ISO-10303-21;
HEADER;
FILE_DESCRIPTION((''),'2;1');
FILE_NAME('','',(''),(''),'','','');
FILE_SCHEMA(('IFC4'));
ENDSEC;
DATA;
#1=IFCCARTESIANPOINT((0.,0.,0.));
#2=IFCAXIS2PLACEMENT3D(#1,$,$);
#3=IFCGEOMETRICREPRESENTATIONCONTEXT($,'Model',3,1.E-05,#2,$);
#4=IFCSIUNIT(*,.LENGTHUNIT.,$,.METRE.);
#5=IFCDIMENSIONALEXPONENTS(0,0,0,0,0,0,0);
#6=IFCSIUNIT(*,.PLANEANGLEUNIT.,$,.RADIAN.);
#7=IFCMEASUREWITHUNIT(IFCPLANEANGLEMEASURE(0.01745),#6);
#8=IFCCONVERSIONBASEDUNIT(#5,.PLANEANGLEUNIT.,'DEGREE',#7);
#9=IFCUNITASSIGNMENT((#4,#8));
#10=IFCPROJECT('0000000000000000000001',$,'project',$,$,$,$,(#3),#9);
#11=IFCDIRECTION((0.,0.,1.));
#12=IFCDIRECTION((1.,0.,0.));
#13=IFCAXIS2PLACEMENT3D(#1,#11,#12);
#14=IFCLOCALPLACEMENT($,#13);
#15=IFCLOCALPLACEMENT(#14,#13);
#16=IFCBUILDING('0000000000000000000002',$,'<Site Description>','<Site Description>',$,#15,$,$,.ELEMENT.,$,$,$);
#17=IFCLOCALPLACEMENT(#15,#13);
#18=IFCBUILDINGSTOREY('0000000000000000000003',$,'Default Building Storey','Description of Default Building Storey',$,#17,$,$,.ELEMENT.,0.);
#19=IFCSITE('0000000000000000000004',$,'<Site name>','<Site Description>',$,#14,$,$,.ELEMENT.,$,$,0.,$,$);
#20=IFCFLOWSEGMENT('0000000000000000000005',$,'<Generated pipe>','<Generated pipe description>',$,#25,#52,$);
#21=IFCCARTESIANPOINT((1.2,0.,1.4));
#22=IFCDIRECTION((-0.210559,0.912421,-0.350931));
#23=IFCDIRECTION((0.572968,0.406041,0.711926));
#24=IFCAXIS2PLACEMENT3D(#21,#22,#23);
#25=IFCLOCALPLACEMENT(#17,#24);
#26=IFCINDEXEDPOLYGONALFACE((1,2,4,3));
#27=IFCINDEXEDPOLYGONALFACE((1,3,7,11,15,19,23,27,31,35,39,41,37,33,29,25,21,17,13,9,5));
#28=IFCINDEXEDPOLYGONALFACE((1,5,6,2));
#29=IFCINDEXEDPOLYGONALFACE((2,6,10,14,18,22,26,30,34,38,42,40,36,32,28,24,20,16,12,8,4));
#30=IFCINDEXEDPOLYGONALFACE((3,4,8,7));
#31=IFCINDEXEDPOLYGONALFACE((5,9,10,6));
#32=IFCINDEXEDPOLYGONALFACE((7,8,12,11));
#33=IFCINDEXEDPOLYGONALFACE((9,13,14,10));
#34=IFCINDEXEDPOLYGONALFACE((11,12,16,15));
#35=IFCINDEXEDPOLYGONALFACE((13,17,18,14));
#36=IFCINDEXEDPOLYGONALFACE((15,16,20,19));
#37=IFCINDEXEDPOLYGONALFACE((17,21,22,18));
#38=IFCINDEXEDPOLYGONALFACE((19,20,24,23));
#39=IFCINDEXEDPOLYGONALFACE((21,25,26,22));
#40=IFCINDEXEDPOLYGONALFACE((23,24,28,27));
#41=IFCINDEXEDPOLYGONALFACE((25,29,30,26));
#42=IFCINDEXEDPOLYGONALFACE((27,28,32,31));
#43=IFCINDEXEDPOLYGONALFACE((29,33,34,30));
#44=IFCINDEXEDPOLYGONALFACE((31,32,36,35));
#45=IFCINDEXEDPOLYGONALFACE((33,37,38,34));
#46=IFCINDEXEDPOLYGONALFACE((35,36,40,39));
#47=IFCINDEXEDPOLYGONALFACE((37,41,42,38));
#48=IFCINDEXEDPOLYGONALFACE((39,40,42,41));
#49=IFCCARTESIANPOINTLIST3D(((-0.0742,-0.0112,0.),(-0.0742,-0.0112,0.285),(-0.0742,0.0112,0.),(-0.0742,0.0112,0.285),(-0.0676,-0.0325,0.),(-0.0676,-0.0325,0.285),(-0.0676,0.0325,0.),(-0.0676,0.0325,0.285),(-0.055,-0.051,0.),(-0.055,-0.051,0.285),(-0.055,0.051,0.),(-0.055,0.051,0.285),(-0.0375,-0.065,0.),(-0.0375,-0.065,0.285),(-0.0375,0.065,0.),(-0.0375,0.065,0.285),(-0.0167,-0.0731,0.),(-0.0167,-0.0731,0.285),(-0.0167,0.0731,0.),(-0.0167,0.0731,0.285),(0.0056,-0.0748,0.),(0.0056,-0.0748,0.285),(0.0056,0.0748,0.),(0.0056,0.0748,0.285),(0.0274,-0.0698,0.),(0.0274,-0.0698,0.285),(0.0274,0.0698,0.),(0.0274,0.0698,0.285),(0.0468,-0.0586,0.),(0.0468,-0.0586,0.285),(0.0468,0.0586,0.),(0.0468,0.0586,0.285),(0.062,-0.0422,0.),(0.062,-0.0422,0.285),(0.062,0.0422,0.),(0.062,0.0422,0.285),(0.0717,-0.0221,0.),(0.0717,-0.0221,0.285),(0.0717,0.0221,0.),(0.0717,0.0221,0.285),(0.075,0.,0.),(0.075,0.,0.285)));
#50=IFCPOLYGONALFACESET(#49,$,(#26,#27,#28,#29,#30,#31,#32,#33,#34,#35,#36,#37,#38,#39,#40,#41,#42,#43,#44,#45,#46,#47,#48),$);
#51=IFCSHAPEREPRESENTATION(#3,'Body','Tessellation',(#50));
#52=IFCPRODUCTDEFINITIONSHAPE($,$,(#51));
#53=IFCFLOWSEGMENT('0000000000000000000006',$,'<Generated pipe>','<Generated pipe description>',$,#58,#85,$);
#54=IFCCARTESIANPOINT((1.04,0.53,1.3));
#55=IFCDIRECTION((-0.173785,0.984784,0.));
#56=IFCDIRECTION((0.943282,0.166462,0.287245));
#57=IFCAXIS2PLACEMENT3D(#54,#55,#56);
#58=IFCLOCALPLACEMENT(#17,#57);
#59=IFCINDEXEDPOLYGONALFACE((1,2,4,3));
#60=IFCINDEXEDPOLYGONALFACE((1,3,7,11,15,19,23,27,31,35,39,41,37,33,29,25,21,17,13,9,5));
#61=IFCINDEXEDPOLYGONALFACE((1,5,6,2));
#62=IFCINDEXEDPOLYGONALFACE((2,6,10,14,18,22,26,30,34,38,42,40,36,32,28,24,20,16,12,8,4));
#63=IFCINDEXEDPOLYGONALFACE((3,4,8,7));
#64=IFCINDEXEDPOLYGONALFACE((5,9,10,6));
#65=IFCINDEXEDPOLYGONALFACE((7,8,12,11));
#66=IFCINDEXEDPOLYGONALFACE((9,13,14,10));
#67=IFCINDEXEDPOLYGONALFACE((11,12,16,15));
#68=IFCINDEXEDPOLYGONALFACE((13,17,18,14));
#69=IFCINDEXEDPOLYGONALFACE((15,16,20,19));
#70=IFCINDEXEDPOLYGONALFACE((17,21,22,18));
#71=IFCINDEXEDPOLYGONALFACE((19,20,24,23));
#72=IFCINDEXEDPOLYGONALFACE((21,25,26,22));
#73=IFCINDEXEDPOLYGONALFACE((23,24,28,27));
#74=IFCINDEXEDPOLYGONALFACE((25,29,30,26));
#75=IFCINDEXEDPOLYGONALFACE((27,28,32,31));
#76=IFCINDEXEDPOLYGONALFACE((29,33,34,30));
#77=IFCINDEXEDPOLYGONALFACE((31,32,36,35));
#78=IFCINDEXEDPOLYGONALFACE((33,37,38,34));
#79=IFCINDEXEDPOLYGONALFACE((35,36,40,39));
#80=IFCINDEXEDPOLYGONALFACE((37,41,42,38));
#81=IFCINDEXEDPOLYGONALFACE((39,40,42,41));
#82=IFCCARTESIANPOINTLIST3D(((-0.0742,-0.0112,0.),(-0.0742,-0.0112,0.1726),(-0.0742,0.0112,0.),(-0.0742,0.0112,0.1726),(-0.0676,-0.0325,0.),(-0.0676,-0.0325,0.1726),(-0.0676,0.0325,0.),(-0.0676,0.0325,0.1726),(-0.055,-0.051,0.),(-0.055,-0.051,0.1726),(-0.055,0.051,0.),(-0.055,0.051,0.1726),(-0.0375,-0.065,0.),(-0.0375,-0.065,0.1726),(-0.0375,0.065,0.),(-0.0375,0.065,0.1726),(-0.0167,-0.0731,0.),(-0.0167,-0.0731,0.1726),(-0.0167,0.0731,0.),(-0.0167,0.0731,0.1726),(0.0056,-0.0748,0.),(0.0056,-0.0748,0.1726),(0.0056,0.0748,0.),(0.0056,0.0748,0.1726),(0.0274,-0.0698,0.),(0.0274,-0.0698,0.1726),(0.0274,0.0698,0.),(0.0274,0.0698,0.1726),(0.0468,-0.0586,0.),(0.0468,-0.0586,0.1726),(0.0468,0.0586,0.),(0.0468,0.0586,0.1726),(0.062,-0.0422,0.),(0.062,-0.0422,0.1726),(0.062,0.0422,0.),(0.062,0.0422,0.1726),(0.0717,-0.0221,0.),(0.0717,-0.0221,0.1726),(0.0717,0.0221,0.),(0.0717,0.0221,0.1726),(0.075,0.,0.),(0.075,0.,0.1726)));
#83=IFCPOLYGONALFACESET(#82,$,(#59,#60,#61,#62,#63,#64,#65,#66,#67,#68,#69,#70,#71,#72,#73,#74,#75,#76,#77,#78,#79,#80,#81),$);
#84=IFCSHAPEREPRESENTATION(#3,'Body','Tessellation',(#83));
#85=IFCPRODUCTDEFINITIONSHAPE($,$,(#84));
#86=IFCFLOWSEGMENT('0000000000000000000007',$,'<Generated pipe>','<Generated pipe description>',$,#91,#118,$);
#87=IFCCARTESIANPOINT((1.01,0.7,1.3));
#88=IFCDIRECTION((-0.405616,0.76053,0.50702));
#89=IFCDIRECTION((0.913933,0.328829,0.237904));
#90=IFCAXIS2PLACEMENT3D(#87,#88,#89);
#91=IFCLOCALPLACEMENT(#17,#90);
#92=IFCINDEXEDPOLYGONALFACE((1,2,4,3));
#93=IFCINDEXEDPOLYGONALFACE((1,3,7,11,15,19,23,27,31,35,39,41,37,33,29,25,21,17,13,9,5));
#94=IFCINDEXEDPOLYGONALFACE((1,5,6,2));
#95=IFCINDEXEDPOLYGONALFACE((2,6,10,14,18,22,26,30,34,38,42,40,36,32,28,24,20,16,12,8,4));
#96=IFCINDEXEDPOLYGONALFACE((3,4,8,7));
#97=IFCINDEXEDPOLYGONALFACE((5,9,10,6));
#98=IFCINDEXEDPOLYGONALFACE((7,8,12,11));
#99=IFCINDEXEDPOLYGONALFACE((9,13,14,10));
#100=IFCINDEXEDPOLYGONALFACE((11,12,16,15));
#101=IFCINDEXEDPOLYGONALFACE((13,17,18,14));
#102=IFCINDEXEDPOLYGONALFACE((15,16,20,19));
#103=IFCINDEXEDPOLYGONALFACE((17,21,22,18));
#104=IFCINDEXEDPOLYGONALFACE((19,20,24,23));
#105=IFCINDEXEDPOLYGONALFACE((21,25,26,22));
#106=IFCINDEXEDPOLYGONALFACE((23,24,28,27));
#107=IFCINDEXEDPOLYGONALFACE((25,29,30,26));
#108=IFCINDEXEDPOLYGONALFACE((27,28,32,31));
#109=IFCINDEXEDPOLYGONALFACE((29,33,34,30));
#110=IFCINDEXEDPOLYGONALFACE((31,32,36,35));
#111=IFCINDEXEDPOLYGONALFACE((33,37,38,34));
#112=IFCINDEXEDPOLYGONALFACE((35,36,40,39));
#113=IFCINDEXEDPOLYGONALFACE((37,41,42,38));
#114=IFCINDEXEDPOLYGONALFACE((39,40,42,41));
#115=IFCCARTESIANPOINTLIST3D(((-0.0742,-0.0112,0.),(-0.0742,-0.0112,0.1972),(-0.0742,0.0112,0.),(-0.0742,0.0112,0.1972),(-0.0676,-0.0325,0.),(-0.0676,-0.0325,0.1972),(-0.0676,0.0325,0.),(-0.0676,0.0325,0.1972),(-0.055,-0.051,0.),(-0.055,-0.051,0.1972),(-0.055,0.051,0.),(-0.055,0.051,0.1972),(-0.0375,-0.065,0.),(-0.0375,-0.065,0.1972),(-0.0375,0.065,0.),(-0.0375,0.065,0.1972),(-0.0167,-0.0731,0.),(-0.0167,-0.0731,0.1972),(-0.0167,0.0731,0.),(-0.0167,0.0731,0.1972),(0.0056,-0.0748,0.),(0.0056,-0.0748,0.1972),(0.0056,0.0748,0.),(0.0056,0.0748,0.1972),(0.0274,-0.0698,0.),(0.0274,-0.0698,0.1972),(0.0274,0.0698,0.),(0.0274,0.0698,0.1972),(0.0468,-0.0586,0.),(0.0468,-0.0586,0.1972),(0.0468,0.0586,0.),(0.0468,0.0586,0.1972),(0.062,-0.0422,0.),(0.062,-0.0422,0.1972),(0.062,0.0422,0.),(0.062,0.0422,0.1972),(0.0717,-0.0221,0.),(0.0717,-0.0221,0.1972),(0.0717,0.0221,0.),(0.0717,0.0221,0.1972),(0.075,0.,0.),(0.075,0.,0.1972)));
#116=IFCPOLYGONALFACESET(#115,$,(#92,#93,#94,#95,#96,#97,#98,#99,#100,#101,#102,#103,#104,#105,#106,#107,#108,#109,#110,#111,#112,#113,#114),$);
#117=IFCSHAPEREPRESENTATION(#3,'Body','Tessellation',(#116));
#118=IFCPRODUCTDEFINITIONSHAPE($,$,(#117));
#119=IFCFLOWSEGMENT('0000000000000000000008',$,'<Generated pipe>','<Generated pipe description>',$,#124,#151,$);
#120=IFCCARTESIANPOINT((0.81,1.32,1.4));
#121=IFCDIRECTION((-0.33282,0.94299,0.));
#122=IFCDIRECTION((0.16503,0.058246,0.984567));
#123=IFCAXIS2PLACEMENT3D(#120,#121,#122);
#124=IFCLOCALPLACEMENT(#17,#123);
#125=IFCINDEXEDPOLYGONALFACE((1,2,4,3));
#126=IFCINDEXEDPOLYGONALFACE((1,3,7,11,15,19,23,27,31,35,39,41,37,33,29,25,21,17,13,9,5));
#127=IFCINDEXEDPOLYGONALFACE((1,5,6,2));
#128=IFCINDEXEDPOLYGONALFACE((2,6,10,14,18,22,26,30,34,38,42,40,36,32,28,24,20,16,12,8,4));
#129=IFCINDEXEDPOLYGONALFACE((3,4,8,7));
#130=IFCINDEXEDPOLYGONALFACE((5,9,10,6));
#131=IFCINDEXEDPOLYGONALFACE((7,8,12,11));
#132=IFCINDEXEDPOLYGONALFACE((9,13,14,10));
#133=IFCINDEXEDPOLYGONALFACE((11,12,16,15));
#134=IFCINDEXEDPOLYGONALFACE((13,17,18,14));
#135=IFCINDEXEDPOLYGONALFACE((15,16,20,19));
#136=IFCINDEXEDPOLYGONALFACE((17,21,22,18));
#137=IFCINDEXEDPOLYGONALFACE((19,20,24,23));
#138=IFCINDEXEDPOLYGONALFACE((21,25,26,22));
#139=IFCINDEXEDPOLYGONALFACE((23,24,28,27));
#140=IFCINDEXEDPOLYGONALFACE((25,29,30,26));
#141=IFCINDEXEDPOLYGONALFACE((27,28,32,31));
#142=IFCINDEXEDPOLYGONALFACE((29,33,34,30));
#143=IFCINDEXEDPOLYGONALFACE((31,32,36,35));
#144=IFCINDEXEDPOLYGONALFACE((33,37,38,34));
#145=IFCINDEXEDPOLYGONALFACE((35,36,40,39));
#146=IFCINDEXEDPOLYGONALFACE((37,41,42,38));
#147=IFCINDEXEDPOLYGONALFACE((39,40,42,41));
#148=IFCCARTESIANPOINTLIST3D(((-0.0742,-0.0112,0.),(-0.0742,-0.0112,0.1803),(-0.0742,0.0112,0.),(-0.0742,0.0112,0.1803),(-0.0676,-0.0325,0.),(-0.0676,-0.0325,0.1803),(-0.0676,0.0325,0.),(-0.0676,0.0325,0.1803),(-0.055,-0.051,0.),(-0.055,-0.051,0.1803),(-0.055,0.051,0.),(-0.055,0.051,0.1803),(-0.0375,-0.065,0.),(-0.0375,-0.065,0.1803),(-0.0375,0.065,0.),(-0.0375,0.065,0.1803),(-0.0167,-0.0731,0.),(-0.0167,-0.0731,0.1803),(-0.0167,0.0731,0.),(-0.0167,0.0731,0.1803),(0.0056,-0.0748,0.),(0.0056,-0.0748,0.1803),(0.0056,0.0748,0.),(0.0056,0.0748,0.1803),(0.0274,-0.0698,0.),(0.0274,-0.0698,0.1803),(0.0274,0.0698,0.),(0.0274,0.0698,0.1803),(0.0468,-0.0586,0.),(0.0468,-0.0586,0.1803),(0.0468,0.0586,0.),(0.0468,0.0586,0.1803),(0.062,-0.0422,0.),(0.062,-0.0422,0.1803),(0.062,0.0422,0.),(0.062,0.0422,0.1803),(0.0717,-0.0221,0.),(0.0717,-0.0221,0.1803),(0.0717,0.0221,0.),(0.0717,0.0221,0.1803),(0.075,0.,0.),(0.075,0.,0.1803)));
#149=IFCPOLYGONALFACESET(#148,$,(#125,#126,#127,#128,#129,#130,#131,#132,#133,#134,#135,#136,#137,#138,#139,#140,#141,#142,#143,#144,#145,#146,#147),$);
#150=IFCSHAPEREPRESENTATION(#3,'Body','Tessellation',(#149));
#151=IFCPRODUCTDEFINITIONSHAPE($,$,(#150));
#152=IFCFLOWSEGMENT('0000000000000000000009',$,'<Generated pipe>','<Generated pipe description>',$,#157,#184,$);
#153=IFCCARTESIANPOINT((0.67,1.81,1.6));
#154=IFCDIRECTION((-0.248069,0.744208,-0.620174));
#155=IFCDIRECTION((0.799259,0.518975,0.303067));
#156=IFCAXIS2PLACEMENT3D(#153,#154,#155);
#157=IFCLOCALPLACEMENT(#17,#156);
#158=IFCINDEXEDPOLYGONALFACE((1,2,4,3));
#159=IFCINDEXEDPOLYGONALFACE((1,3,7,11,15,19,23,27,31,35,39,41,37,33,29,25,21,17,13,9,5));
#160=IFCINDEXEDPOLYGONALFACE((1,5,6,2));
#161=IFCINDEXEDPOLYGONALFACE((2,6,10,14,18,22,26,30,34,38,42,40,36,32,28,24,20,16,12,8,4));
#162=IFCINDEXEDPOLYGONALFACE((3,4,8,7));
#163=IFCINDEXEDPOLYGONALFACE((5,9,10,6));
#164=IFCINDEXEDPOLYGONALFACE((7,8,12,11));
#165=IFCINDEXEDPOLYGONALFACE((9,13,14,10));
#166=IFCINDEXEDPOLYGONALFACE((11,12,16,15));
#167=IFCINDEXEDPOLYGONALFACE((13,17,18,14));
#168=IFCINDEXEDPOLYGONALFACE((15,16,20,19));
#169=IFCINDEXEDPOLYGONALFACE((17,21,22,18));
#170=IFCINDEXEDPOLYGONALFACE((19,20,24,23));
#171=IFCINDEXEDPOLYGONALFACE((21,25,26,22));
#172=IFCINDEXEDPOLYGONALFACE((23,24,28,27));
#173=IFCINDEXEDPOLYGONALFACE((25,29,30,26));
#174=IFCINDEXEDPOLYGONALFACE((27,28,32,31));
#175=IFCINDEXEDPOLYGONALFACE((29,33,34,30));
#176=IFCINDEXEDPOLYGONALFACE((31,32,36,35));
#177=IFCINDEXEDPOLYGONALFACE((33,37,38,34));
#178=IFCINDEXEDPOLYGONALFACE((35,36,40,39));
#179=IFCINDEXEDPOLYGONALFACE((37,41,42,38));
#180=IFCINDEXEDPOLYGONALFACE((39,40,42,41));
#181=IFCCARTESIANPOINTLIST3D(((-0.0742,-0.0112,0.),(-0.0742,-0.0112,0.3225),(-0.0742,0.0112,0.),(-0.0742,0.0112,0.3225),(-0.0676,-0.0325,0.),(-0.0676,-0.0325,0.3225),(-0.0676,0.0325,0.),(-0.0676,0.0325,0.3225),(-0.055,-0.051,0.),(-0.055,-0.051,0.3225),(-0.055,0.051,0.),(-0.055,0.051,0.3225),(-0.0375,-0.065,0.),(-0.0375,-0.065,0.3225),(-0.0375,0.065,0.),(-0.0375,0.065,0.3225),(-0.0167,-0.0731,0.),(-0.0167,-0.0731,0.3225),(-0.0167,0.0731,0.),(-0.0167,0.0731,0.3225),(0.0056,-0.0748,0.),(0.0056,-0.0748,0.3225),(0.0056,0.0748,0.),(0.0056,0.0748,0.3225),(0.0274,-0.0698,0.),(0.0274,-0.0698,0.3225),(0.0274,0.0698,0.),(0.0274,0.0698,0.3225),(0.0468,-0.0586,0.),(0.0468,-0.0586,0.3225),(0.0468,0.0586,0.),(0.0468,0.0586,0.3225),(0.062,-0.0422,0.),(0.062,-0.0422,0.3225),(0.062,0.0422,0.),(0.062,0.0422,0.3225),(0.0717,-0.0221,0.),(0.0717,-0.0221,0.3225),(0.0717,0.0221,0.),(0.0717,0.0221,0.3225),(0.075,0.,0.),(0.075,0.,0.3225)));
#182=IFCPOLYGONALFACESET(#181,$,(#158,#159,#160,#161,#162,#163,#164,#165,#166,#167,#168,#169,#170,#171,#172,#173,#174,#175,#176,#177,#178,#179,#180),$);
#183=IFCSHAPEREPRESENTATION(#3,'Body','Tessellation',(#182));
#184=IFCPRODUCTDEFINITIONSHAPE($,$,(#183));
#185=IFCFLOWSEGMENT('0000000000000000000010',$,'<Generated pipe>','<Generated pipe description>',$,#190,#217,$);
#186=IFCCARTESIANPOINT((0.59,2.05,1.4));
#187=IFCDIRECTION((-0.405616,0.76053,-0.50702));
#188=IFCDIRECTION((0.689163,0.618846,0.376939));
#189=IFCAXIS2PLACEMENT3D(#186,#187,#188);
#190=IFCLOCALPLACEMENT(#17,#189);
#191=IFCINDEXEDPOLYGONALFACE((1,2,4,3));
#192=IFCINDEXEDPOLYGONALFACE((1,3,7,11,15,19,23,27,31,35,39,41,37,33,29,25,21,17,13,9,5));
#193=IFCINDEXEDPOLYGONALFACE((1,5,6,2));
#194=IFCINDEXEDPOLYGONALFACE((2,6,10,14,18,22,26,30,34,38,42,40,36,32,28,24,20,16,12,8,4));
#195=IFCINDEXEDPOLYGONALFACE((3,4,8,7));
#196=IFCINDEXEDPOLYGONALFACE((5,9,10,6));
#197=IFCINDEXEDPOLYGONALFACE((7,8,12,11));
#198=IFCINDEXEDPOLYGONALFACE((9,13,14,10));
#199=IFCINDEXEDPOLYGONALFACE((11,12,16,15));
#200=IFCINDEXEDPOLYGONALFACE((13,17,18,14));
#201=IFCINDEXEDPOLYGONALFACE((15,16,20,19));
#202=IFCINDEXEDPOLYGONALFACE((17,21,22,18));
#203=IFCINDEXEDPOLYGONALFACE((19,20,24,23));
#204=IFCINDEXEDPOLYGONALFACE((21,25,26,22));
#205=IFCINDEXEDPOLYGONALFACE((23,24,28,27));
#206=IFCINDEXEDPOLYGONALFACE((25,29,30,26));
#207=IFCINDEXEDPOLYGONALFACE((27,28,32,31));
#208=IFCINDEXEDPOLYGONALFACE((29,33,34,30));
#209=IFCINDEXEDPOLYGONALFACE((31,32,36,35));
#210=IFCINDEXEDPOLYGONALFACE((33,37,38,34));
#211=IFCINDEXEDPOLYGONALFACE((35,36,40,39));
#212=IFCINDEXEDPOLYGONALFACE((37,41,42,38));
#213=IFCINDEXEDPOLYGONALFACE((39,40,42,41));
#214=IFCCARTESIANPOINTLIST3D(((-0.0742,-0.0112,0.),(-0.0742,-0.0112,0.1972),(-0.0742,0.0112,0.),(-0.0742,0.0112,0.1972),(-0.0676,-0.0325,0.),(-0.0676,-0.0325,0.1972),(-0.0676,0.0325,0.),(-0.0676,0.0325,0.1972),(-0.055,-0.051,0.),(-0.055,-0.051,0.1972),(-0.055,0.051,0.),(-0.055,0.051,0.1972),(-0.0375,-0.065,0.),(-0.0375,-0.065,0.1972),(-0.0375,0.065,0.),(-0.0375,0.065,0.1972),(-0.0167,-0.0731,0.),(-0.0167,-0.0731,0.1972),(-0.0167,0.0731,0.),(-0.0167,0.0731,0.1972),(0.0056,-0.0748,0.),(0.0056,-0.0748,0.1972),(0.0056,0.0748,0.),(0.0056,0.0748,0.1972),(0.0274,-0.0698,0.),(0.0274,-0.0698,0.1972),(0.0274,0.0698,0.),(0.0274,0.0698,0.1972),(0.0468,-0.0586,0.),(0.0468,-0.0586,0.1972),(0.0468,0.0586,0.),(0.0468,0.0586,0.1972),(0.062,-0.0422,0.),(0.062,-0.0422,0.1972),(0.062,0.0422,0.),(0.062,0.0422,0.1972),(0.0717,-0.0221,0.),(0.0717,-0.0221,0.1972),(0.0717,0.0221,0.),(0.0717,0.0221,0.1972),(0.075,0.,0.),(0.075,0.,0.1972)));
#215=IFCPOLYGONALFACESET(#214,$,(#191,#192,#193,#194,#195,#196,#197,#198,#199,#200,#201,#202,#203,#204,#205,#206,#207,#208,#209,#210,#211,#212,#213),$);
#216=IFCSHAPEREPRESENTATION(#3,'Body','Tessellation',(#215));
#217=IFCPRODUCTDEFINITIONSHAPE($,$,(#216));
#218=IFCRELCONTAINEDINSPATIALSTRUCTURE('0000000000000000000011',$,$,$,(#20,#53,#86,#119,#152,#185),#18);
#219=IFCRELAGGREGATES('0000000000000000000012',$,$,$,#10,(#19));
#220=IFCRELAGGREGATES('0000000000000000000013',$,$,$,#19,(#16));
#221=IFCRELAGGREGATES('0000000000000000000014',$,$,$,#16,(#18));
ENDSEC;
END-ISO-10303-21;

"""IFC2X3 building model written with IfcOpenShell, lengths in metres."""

from ifc_helpers import new_model, entity, si_unit, converted_unit, frame, origin, origin_with_axes, origin_2d_with_axis, place, context, project, spatial, circle, extrude, element, save


model = new_model("IFC2X3")

# Units and contexts
model_context = context("Model", 3, precision=1e-05, world=origin())
ifc_project = project(units=[si_unit("LENGTHUNIT", "METRE"), converted_unit("PLANEANGLEUNIT", "DEGREE", entity("IfcPlaneAngleMeasure", 0.01745), si_unit("PLANEANGLEUNIT", "RADIAN"), dimensions=[0, 0, 0, 0, 0, 0, 0])], contexts=[model_context])

# Site, building, storey
site_placement = place(None, origin_with_axes())
site = spatial("IfcSite", under=ifc_project, at=site_placement, Name="<Site name>", Description="<Site Description>", CompositionType="ELEMENT", RefElevation=0.0)
building_placement = place(site_placement, origin_with_axes())
building = spatial("IfcBuilding", under=site, at=building_placement, Name="<Site Description>", Description="<Site Description>", CompositionType="ELEMENT")
storey_placement = place(building_placement, origin_with_axes())
storey = spatial("IfcBuildingStorey", under=building, at=storey_placement, Name="Default Building Storey", Description="Description of Default Building Storey", CompositionType="ELEMENT", Elevation=0.0)

# Flow segments
flow_segment_1_placement = place(storey_placement, frame((1.2, 0.0, 1.4), z_axis=(-0.210559, 0.912421, -0.350931), x_axis=(0.572968, 0.406041, 0.711926)))
element("IfcFlowSegment", 1, at=flow_segment_1_placement, inside=storey, Name="<Generated pipe>", Description="<Generated pipe description>", context=model_context, shape_type="SweptSolid", body=[
    extrude(circle(Radius=0.075, at=origin_2d_with_axis()), origin_with_axes(), (0.0, 0.0, 1.0), 0.285),
])
flow_segment_2_placement = place(storey_placement, frame((1.04, 0.53, 1.3), z_axis=(-0.173785, 0.984784, 0.0), x_axis=(0.943282, 0.166462, 0.287245)))
element("IfcFlowSegment", 2, at=flow_segment_2_placement, inside=storey, Name="<Generated pipe>", Description="<Generated pipe description>", context=model_context, shape_type="SweptSolid", body=[
    extrude(circle(Radius=0.075, at=origin_2d_with_axis()), origin_with_axes(), (0.0, 0.0, 1.0), 0.1726),
])
flow_segment_3_placement = place(storey_placement, frame((1.01, 0.7, 1.3), z_axis=(-0.405616, 0.76053, 0.50702), x_axis=(0.913933, 0.328829, 0.237904)))
element("IfcFlowSegment", 3, at=flow_segment_3_placement, inside=storey, Name="<Generated pipe>", Description="<Generated pipe description>", context=model_context, shape_type="SweptSolid", body=[
    extrude(circle(Radius=0.075, at=origin_2d_with_axis()), origin_with_axes(), (0.0, 0.0, 1.0), 0.1972),
])
flow_segment_4_placement = place(storey_placement, frame((0.81, 1.32, 1.4), z_axis=(-0.33282, 0.94299, 0.0), x_axis=(0.16503, 0.058246, 0.984567)))
element("IfcFlowSegment", 4, at=flow_segment_4_placement, inside=storey, Name="<Generated pipe>", Description="<Generated pipe description>", context=model_context, shape_type="SweptSolid", body=[
    extrude(circle(Radius=0.075, at=origin_2d_with_axis()), origin_with_axes(), (0.0, 0.0, 1.0), 0.1803),
])
flow_segment_5_placement = place(storey_placement, frame((0.67, 1.81, 1.6), z_axis=(-0.248069, 0.744208, -0.620174), x_axis=(0.799259, 0.518975, 0.303067)))
element("IfcFlowSegment", 5, at=flow_segment_5_placement, inside=storey, Name="<Generated pipe>", Description="<Generated pipe description>", context=model_context, shape_type="SweptSolid", body=[
    extrude(circle(Radius=0.075, at=origin_2d_with_axis()), origin_with_axes(), (0.0, 0.0, 1.0), 0.3225),
])
flow_segment_6_placement = place(storey_placement, frame((0.59, 2.05, 1.4), z_axis=(-0.405616, 0.76053, -0.50702), x_axis=(0.689163, 0.618846, 0.376939)))
element("IfcFlowSegment", 6, at=flow_segment_6_placement, inside=storey, Name="<Generated pipe>", Description="<Generated pipe description>", context=model_context, shape_type="SweptSolid", body=[
    extrude(circle(Radius=0.075, at=origin_2d_with_axis()), origin_with_axes(), (0.0, 0.0, 1.0), 0.1972),
])

save(model, "model.ifc")
